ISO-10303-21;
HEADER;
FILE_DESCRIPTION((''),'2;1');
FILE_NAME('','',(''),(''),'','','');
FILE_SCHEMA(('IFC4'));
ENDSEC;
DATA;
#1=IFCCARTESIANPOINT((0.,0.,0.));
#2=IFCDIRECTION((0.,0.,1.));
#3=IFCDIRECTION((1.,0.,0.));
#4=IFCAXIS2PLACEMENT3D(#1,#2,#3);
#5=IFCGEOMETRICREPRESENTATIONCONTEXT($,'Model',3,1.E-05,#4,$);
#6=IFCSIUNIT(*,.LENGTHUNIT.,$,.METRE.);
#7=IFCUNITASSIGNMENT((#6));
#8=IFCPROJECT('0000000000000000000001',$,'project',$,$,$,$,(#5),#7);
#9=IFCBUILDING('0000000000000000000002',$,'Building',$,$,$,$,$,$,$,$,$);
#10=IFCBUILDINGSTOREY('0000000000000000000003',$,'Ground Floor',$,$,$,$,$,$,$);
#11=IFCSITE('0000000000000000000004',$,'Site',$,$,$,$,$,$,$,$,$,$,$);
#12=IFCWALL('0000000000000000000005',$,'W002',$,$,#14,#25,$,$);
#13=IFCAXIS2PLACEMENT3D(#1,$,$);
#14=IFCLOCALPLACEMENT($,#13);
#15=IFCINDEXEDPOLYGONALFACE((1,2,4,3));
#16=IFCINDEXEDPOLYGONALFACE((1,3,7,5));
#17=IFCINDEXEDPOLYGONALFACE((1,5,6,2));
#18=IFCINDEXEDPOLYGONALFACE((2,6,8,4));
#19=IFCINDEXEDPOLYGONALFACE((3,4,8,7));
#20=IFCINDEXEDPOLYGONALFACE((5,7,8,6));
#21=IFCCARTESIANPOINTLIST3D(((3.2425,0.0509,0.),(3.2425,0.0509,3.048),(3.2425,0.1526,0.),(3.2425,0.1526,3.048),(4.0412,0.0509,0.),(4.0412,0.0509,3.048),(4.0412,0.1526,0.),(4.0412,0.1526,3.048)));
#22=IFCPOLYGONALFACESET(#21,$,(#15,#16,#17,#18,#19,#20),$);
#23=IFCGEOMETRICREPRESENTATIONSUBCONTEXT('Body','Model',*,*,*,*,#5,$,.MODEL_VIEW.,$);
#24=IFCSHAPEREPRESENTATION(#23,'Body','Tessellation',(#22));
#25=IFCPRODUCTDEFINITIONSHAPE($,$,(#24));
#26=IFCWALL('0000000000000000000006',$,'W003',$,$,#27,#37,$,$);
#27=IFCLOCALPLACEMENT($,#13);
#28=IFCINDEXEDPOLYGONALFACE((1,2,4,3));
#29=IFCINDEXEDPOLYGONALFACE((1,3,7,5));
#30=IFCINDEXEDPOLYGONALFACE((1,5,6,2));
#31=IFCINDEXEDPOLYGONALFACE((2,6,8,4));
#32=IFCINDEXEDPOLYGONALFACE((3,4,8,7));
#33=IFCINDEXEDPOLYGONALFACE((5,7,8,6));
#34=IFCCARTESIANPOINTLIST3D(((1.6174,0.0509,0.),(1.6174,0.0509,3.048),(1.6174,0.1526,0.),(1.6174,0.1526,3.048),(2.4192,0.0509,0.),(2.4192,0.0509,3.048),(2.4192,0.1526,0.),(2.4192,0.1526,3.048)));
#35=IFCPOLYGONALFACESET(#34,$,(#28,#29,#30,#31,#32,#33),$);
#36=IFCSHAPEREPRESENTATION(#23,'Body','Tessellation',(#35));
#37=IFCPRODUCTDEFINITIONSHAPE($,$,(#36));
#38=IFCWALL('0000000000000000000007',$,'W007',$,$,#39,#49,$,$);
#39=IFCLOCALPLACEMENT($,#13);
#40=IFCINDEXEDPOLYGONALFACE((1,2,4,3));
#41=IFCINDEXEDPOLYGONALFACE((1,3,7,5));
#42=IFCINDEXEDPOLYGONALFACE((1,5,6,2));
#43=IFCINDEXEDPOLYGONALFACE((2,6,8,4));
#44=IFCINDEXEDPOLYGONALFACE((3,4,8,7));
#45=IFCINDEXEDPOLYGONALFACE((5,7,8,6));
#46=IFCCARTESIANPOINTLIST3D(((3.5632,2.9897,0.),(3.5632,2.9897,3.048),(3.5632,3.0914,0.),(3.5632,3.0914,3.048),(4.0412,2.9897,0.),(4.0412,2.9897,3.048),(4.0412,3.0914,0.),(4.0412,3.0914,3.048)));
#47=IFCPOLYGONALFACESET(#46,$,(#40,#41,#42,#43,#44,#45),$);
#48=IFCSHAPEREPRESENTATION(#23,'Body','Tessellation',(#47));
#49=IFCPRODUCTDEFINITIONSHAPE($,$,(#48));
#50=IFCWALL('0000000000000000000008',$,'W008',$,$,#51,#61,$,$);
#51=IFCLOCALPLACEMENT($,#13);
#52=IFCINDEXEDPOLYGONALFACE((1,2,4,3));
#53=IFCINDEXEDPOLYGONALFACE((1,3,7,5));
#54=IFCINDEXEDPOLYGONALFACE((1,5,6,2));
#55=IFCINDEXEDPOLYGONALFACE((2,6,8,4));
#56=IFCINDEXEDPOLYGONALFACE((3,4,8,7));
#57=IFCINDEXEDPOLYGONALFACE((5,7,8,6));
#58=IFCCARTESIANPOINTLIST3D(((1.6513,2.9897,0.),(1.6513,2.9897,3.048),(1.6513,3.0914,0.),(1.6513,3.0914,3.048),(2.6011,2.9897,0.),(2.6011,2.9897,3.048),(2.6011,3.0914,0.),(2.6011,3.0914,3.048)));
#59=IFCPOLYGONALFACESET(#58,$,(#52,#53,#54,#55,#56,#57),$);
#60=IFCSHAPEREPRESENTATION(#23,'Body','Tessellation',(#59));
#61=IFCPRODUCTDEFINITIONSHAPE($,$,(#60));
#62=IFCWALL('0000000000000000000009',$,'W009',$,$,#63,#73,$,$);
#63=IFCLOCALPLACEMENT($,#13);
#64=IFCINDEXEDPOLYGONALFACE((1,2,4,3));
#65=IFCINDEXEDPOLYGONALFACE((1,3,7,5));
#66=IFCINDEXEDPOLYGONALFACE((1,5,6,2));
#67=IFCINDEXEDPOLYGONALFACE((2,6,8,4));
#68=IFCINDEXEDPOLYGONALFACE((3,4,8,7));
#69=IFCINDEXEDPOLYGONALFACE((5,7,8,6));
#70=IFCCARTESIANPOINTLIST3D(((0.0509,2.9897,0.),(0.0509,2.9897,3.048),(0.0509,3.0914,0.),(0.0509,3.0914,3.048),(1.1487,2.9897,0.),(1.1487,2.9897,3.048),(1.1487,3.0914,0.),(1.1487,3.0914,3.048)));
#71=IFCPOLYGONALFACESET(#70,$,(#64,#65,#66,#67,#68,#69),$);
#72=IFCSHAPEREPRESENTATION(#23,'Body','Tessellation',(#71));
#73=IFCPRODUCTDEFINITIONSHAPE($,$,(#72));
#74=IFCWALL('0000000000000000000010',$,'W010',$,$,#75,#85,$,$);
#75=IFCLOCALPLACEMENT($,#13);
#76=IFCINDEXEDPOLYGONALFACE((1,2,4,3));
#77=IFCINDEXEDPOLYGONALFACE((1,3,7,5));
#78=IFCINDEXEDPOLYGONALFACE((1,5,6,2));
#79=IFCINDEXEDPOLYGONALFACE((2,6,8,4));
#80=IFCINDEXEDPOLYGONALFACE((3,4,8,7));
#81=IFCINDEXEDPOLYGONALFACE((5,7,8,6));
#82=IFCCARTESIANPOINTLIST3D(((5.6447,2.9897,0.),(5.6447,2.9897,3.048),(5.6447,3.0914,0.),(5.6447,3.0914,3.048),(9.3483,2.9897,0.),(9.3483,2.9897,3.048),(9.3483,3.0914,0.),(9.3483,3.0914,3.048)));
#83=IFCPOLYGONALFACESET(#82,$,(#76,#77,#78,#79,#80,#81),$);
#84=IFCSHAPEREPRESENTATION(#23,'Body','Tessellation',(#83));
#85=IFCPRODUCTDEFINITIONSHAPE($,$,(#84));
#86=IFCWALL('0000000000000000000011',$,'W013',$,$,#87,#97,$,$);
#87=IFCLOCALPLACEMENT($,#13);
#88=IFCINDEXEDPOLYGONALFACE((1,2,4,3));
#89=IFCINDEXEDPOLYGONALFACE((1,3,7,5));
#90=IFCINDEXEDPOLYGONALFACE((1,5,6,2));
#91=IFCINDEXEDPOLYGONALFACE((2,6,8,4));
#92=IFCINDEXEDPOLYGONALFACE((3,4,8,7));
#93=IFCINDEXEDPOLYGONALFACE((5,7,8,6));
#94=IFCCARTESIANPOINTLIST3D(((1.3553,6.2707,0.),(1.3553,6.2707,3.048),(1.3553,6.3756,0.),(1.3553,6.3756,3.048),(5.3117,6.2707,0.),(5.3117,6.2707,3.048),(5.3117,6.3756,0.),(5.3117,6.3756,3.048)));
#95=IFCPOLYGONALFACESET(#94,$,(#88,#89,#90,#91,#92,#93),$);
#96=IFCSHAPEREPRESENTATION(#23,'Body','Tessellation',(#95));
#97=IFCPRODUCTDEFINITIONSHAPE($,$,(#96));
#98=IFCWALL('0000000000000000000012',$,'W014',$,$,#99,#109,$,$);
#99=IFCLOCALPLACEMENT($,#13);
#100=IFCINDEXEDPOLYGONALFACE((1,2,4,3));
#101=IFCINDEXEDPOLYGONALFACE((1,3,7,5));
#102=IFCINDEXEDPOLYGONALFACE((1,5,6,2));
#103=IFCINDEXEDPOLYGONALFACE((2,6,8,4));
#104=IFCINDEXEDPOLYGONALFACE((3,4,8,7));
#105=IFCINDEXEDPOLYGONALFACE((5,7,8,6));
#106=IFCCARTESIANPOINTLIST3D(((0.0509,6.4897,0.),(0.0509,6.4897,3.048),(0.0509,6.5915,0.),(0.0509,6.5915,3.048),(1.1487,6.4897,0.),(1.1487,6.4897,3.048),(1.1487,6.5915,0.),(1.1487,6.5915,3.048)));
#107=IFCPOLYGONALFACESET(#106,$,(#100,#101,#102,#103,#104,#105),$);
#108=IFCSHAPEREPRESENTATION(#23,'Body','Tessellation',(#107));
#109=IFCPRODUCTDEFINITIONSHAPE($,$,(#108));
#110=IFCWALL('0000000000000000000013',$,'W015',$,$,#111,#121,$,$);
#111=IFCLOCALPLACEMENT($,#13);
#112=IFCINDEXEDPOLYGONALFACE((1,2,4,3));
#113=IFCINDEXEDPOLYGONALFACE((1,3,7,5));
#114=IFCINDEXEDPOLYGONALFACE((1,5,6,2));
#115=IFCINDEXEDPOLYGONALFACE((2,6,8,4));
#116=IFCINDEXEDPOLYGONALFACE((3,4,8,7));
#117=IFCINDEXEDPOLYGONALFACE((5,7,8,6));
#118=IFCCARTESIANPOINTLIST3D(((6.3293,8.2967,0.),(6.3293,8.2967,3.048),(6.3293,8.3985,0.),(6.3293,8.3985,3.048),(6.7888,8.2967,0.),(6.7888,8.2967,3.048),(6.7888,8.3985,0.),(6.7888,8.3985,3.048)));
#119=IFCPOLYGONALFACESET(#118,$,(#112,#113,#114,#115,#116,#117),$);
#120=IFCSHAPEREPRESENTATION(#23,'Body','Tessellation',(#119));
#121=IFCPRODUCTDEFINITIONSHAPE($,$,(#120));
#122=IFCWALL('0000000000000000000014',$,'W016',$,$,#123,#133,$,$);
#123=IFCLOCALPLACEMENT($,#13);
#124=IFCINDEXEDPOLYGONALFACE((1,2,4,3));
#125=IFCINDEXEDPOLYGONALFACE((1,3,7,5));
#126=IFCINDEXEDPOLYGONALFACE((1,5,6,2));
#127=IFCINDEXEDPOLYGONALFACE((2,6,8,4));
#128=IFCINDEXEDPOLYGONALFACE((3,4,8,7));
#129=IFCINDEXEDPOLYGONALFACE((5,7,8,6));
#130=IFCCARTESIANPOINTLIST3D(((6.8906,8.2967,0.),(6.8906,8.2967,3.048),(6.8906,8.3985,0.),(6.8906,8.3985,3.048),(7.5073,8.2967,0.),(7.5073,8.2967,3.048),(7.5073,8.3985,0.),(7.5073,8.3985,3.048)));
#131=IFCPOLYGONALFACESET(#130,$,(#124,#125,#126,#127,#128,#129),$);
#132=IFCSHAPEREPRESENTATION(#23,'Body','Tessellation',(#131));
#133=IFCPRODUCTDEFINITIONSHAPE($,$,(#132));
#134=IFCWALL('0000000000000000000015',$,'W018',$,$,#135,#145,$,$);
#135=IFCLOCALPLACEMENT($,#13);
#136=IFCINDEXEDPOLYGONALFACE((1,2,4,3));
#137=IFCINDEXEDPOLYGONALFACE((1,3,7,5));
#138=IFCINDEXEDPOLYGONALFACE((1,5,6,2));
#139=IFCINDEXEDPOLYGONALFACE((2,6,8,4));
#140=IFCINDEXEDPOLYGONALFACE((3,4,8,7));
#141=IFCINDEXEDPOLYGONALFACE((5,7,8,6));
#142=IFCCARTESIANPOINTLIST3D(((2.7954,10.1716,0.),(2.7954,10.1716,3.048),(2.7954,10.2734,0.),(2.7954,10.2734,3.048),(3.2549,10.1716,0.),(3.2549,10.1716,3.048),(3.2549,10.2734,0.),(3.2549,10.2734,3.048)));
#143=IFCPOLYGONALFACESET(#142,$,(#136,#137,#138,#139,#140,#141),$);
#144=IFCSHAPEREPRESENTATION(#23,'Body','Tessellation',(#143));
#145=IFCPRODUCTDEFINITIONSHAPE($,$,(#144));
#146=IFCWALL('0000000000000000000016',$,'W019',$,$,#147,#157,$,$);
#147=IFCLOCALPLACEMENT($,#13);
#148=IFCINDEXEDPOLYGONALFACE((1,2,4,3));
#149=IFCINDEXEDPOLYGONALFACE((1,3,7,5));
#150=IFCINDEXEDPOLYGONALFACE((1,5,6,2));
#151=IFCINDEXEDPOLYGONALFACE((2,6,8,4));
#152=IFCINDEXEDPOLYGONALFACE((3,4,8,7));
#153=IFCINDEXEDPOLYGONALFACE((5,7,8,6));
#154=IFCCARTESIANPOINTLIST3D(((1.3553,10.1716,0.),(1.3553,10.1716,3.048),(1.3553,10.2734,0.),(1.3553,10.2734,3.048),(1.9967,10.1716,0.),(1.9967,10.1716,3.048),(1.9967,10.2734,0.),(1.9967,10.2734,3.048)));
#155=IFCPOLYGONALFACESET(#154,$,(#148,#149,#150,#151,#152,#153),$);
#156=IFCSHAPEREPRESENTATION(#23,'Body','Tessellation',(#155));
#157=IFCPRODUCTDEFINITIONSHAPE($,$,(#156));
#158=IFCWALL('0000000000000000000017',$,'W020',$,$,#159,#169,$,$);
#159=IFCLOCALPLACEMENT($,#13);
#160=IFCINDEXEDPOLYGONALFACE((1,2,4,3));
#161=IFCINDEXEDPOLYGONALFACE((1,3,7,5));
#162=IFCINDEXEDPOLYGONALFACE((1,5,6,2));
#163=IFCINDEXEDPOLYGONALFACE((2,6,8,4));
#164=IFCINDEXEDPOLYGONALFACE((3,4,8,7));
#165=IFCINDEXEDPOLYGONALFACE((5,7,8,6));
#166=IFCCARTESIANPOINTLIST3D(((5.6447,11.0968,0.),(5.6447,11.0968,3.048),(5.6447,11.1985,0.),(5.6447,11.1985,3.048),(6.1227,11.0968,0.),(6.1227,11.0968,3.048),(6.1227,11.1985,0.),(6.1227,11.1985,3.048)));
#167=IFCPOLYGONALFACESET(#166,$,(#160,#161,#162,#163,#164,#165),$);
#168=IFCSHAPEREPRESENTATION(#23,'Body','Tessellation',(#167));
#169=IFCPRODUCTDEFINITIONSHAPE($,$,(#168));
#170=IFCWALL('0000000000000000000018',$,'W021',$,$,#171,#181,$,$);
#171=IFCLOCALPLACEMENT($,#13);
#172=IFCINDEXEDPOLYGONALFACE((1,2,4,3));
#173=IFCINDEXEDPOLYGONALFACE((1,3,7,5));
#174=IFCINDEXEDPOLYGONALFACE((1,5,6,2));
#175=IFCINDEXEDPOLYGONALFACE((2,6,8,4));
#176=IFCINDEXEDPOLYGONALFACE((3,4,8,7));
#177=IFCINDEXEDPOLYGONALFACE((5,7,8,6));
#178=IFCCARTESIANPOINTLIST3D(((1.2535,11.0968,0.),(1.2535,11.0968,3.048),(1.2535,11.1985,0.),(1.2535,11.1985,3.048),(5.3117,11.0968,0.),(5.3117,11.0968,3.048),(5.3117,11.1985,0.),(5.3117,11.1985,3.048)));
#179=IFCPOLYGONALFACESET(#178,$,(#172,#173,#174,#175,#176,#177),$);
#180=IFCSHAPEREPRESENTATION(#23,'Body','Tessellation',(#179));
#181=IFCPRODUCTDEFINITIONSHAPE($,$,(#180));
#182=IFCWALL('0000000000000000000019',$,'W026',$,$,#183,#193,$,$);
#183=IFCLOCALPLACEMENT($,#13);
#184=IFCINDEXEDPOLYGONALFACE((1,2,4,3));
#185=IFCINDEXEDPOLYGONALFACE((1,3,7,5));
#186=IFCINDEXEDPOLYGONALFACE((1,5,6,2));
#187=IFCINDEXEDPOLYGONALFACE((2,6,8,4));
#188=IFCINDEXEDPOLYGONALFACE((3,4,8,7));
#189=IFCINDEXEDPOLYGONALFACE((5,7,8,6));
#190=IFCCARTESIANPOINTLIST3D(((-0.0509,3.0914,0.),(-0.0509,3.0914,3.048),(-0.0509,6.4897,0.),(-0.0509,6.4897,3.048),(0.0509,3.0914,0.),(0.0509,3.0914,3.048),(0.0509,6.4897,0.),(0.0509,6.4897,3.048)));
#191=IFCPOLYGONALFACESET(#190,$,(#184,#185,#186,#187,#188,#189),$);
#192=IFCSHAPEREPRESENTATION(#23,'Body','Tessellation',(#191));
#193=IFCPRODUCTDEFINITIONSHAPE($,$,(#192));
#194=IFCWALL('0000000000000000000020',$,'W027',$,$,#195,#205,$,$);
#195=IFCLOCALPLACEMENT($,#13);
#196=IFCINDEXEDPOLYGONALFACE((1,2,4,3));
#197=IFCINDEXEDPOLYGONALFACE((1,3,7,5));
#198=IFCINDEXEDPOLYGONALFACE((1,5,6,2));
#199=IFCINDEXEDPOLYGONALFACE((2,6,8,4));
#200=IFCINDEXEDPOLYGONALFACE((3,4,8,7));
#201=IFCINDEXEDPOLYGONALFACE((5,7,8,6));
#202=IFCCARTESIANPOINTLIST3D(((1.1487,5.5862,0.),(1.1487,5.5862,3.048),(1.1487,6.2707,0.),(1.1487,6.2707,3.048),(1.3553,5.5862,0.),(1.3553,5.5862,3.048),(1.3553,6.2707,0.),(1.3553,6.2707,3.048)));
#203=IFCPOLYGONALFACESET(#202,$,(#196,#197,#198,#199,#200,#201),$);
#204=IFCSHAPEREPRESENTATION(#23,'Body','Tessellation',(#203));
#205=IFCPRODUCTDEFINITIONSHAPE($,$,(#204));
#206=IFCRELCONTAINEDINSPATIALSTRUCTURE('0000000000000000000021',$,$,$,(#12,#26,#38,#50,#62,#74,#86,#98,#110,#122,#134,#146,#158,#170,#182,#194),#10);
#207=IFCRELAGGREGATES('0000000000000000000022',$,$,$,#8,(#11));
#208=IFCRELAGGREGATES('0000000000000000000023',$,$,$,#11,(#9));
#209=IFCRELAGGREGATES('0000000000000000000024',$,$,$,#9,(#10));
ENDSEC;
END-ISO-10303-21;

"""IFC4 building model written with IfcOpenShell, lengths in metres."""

from ifc_helpers import new_model, si_unit, frame, origin_with_axes, place, context, subcontext, project, spatial, line, indexed_curve, outline, extrude, element, save


model = new_model("IFC4")

# Units and contexts
model_context = context("Model", 3, precision=1e-05, world=origin_with_axes())
body_context = subcontext(model_context, "Body", "Model", "MODEL_VIEW")
ifc_project = project(units=[si_unit("LENGTHUNIT", "METRE")], contexts=[model_context])

# Site, building, storey
site = spatial("IfcSite", under=ifc_project, Name="Site")
building = spatial("IfcBuilding", under=site, Name="Building")
storey = spatial("IfcBuildingStorey", under=building, Name="Ground Floor")

# Walls
wall_1_placement = place(None, frame((3.2425, 0.1018, 0.0), z_axis=(0.0, 0.0, 1.0), x_axis=(1.0, 0.0, 0.0)))
element("IfcWall", 1, at=wall_1_placement, inside=storey, Name="W002", context=body_context, shape_type="SweptSolid", body=[
    extrude(outline(indexed_curve([(0.0, -0.0509), (0.7987, -0.0509), (0.7987, 0.0509), (0.0, 0.0509)], segments=[line(1, 2, 3, 4, 1)])), origin_with_axes(), (0.0, 0.0, 1.0), 3.048),
])
wall_2_placement = place(None, frame((1.6174, 0.1018, 0.0), z_axis=(0.0, 0.0, 1.0), x_axis=(1.0, 0.0, 0.0)))
element("IfcWall", 2, at=wall_2_placement, inside=storey, Name="W003", context=body_context, shape_type="SweptSolid", body=[
    extrude(outline(indexed_curve([(0.0, -0.0509), (0.8018, -0.0509), (0.8018, 0.0509), (0.0, 0.0509)], segments=[line(1, 2, 3, 4, 1)])), origin_with_axes(), (0.0, 0.0, 1.0), 3.048),
])
wall_3_placement = place(None, frame((3.5632, 3.0405, 0.0), z_axis=(0.0, 0.0, 1.0), x_axis=(1.0, 0.0, 0.0)))
element("IfcWall", 3, at=wall_3_placement, inside=storey, Name="W007", context=body_context, shape_type="SweptSolid", body=[
    extrude(outline(indexed_curve([(0.0, -0.0509), (0.478, -0.0509), (0.478, 0.0509), (0.0, 0.0509)], segments=[line(1, 2, 3, 4, 1)])), origin_with_axes(), (0.0, 0.0, 1.0), 3.048),
])
wall_4_placement = place(None, frame((1.6513, 3.0405, 0.0), z_axis=(0.0, 0.0, 1.0), x_axis=(1.0, 0.0, 0.0)))
element("IfcWall", 4, at=wall_4_placement, inside=storey, Name="W008", context=body_context, shape_type="SweptSolid", body=[
    extrude(outline(indexed_curve([(0.0, -0.0509), (0.9498, -0.0509), (0.9498, 0.0509), (0.0, 0.0509)], segments=[line(1, 2, 3, 4, 1)])), origin_with_axes(), (0.0, 0.0, 1.0), 3.048),
])
wall_5_placement = place(None, frame((0.0509, 3.0405, 0.0), z_axis=(0.0, 0.0, 1.0), x_axis=(1.0, 0.0, 0.0)))
element("IfcWall", 5, at=wall_5_placement, inside=storey, Name="W009", context=body_context, shape_type="SweptSolid", body=[
    extrude(outline(indexed_curve([(0.0, -0.0509), (1.0978, -0.0509), (1.0978, 0.0509), (0.0, 0.0509)], segments=[line(1, 2, 3, 4, 1)])), origin_with_axes(), (0.0, 0.0, 1.0), 3.048),
])
wall_6_placement = place(None, frame((5.6447, 3.0405, 0.0), z_axis=(0.0, 0.0, 1.0), x_axis=(1.0, 0.0, 0.0)))
element("IfcWall", 6, at=wall_6_placement, inside=storey, Name="W010", context=body_context, shape_type="SweptSolid", body=[
    extrude(outline(indexed_curve([(0.0, -0.0509), (3.7035, -0.0509), (3.7035, 0.0509), (0.0, 0.0509)], segments=[line(1, 2, 3, 4, 1)])), origin_with_axes(), (0.0, 0.0, 1.0), 3.048),
])
wall_7_placement = place(None, frame((1.3553, 6.3232, 0.0), z_axis=(0.0, 0.0, 1.0), x_axis=(1.0, 0.0, 0.0)))
element("IfcWall", 7, at=wall_7_placement, inside=storey, Name="W013", context=body_context, shape_type="SweptSolid", body=[
    extrude(outline(indexed_curve([(0.0, -0.0524), (3.9564, -0.0524), (3.9564, 0.0524), (0.0, 0.0524)], segments=[line(1, 2, 3, 4, 1)])), origin_with_axes(), (0.0, 0.0, 1.0), 3.048),
])
wall_8_placement = place(None, frame((0.0509, 6.5406, 0.0), z_axis=(0.0, 0.0, 1.0), x_axis=(1.0, 0.0, 0.0)))
element("IfcWall", 8, at=wall_8_placement, inside=storey, Name="W014", context=body_context, shape_type="SweptSolid", body=[
    extrude(outline(indexed_curve([(0.0, -0.0509), (1.0978, -0.0509), (1.0978, 0.0509), (0.0, 0.0509)], segments=[line(1, 2, 3, 4, 1)])), origin_with_axes(), (0.0, 0.0, 1.0), 3.048),
])
wall_9_placement = place(None, frame((6.3293, 8.3476, 0.0), z_axis=(0.0, 0.0, 1.0), x_axis=(1.0, 0.0, 0.0)))
element("IfcWall", 9, at=wall_9_placement, inside=storey, Name="W015", context=body_context, shape_type="SweptSolid", body=[
    extrude(outline(indexed_curve([(0.0, -0.0509), (0.4595, -0.0509), (0.4595, 0.0509), (0.0, 0.0509)], segments=[line(1, 2, 3, 4, 1)])), origin_with_axes(), (0.0, 0.0, 1.0), 3.048),
])
wall_10_placement = place(None, frame((6.8906, 8.3476, 0.0), z_axis=(0.0, 0.0, 1.0), x_axis=(1.0, 0.0, 0.0)))
element("IfcWall", 10, at=wall_10_placement, inside=storey, Name="W016", context=body_context, shape_type="SweptSolid", body=[
    extrude(outline(indexed_curve([(0.0, -0.0509), (0.6167, -0.0509), (0.6167, 0.0509), (0.0, 0.0509)], segments=[line(1, 2, 3, 4, 1)])), origin_with_axes(), (0.0, 0.0, 1.0), 3.048),
])
wall_11_placement = place(None, frame((2.7954, 10.2225, 0.0), z_axis=(0.0, 0.0, 1.0), x_axis=(1.0, 0.0, 0.0)))
element("IfcWall", 11, at=wall_11_placement, inside=storey, Name="W018", context=body_context, shape_type="SweptSolid", body=[
    extrude(outline(indexed_curve([(0.0, -0.0509), (0.4595, -0.0509), (0.4595, 0.0509), (0.0, 0.0509)], segments=[line(1, 2, 3, 4, 1)])), origin_with_axes(), (0.0, 0.0, 1.0), 3.048),
])
wall_12_placement = place(None, frame((1.3553, 10.2225, 0.0), z_axis=(0.0, 0.0, 1.0), x_axis=(1.0, 0.0, 0.0)))
element("IfcWall", 12, at=wall_12_placement, inside=storey, Name="W019", context=body_context, shape_type="SweptSolid", body=[
    extrude(outline(indexed_curve([(0.0, -0.0509), (0.6414, -0.0509), (0.6414, 0.0509), (0.0, 0.0509)], segments=[line(1, 2, 3, 4, 1)])), origin_with_axes(), (0.0, 0.0, 1.0), 3.048),
])
wall_13_placement = place(None, frame((5.6447, 11.1476, 0.0), z_axis=(0.0, 0.0, 1.0), x_axis=(1.0, 0.0, 0.0)))
element("IfcWall", 13, at=wall_13_placement, inside=storey, Name="W020", context=body_context, shape_type="SweptSolid", body=[
    extrude(outline(indexed_curve([(0.0, -0.0509), (0.478, -0.0509), (0.478, 0.0509), (0.0, 0.0509)], segments=[line(1, 2, 3, 4, 1)])), origin_with_axes(), (0.0, 0.0, 1.0), 3.048),
])
wall_14_placement = place(None, frame((1.2535, 11.1476, 0.0), z_axis=(0.0, 0.0, 1.0), x_axis=(1.0, 0.0, 0.0)))
element("IfcWall", 14, at=wall_14_placement, inside=storey, Name="W021", context=body_context, shape_type="SweptSolid", body=[
    extrude(outline(indexed_curve([(0.0, -0.0509), (4.0582, -0.0509), (4.0582, 0.0509), (0.0, 0.0509)], segments=[line(1, 2, 3, 4, 1)])), origin_with_axes(), (0.0, 0.0, 1.0), 3.048),
])
wall_15_placement = place(None, frame((0.0, 3.0914, 0.0), z_axis=(0.0, 0.0, 1.0), x_axis=(0.0, 1.0, 0.0)))
element("IfcWall", 15, at=wall_15_placement, inside=storey, Name="W026", context=body_context, shape_type="SweptSolid", body=[
    extrude(outline(indexed_curve([(0.0, -0.0509), (3.3983, -0.0509), (3.3983, 0.0509), (0.0, 0.0509)], segments=[line(1, 2, 3, 4, 1)])), origin_with_axes(), (0.0, 0.0, 1.0), 3.048),
])
wall_16_placement = place(None, frame((1.252, 5.5862, 0.0), z_axis=(0.0, 0.0, 1.0), x_axis=(0.0, 1.0, 0.0)))
element("IfcWall", 16, at=wall_16_placement, inside=storey, Name="W027", context=body_context, shape_type="SweptSolid", body=[
    extrude(outline(indexed_curve([(0.0, -0.1033), (0.6846, -0.1033), (0.6846, 0.1033), (0.0, 0.1033)], segments=[line(1, 2, 3, 4, 1)])), origin_with_axes(), (0.0, 0.0, 1.0), 3.048),
])

save(model, "model.ifc")
